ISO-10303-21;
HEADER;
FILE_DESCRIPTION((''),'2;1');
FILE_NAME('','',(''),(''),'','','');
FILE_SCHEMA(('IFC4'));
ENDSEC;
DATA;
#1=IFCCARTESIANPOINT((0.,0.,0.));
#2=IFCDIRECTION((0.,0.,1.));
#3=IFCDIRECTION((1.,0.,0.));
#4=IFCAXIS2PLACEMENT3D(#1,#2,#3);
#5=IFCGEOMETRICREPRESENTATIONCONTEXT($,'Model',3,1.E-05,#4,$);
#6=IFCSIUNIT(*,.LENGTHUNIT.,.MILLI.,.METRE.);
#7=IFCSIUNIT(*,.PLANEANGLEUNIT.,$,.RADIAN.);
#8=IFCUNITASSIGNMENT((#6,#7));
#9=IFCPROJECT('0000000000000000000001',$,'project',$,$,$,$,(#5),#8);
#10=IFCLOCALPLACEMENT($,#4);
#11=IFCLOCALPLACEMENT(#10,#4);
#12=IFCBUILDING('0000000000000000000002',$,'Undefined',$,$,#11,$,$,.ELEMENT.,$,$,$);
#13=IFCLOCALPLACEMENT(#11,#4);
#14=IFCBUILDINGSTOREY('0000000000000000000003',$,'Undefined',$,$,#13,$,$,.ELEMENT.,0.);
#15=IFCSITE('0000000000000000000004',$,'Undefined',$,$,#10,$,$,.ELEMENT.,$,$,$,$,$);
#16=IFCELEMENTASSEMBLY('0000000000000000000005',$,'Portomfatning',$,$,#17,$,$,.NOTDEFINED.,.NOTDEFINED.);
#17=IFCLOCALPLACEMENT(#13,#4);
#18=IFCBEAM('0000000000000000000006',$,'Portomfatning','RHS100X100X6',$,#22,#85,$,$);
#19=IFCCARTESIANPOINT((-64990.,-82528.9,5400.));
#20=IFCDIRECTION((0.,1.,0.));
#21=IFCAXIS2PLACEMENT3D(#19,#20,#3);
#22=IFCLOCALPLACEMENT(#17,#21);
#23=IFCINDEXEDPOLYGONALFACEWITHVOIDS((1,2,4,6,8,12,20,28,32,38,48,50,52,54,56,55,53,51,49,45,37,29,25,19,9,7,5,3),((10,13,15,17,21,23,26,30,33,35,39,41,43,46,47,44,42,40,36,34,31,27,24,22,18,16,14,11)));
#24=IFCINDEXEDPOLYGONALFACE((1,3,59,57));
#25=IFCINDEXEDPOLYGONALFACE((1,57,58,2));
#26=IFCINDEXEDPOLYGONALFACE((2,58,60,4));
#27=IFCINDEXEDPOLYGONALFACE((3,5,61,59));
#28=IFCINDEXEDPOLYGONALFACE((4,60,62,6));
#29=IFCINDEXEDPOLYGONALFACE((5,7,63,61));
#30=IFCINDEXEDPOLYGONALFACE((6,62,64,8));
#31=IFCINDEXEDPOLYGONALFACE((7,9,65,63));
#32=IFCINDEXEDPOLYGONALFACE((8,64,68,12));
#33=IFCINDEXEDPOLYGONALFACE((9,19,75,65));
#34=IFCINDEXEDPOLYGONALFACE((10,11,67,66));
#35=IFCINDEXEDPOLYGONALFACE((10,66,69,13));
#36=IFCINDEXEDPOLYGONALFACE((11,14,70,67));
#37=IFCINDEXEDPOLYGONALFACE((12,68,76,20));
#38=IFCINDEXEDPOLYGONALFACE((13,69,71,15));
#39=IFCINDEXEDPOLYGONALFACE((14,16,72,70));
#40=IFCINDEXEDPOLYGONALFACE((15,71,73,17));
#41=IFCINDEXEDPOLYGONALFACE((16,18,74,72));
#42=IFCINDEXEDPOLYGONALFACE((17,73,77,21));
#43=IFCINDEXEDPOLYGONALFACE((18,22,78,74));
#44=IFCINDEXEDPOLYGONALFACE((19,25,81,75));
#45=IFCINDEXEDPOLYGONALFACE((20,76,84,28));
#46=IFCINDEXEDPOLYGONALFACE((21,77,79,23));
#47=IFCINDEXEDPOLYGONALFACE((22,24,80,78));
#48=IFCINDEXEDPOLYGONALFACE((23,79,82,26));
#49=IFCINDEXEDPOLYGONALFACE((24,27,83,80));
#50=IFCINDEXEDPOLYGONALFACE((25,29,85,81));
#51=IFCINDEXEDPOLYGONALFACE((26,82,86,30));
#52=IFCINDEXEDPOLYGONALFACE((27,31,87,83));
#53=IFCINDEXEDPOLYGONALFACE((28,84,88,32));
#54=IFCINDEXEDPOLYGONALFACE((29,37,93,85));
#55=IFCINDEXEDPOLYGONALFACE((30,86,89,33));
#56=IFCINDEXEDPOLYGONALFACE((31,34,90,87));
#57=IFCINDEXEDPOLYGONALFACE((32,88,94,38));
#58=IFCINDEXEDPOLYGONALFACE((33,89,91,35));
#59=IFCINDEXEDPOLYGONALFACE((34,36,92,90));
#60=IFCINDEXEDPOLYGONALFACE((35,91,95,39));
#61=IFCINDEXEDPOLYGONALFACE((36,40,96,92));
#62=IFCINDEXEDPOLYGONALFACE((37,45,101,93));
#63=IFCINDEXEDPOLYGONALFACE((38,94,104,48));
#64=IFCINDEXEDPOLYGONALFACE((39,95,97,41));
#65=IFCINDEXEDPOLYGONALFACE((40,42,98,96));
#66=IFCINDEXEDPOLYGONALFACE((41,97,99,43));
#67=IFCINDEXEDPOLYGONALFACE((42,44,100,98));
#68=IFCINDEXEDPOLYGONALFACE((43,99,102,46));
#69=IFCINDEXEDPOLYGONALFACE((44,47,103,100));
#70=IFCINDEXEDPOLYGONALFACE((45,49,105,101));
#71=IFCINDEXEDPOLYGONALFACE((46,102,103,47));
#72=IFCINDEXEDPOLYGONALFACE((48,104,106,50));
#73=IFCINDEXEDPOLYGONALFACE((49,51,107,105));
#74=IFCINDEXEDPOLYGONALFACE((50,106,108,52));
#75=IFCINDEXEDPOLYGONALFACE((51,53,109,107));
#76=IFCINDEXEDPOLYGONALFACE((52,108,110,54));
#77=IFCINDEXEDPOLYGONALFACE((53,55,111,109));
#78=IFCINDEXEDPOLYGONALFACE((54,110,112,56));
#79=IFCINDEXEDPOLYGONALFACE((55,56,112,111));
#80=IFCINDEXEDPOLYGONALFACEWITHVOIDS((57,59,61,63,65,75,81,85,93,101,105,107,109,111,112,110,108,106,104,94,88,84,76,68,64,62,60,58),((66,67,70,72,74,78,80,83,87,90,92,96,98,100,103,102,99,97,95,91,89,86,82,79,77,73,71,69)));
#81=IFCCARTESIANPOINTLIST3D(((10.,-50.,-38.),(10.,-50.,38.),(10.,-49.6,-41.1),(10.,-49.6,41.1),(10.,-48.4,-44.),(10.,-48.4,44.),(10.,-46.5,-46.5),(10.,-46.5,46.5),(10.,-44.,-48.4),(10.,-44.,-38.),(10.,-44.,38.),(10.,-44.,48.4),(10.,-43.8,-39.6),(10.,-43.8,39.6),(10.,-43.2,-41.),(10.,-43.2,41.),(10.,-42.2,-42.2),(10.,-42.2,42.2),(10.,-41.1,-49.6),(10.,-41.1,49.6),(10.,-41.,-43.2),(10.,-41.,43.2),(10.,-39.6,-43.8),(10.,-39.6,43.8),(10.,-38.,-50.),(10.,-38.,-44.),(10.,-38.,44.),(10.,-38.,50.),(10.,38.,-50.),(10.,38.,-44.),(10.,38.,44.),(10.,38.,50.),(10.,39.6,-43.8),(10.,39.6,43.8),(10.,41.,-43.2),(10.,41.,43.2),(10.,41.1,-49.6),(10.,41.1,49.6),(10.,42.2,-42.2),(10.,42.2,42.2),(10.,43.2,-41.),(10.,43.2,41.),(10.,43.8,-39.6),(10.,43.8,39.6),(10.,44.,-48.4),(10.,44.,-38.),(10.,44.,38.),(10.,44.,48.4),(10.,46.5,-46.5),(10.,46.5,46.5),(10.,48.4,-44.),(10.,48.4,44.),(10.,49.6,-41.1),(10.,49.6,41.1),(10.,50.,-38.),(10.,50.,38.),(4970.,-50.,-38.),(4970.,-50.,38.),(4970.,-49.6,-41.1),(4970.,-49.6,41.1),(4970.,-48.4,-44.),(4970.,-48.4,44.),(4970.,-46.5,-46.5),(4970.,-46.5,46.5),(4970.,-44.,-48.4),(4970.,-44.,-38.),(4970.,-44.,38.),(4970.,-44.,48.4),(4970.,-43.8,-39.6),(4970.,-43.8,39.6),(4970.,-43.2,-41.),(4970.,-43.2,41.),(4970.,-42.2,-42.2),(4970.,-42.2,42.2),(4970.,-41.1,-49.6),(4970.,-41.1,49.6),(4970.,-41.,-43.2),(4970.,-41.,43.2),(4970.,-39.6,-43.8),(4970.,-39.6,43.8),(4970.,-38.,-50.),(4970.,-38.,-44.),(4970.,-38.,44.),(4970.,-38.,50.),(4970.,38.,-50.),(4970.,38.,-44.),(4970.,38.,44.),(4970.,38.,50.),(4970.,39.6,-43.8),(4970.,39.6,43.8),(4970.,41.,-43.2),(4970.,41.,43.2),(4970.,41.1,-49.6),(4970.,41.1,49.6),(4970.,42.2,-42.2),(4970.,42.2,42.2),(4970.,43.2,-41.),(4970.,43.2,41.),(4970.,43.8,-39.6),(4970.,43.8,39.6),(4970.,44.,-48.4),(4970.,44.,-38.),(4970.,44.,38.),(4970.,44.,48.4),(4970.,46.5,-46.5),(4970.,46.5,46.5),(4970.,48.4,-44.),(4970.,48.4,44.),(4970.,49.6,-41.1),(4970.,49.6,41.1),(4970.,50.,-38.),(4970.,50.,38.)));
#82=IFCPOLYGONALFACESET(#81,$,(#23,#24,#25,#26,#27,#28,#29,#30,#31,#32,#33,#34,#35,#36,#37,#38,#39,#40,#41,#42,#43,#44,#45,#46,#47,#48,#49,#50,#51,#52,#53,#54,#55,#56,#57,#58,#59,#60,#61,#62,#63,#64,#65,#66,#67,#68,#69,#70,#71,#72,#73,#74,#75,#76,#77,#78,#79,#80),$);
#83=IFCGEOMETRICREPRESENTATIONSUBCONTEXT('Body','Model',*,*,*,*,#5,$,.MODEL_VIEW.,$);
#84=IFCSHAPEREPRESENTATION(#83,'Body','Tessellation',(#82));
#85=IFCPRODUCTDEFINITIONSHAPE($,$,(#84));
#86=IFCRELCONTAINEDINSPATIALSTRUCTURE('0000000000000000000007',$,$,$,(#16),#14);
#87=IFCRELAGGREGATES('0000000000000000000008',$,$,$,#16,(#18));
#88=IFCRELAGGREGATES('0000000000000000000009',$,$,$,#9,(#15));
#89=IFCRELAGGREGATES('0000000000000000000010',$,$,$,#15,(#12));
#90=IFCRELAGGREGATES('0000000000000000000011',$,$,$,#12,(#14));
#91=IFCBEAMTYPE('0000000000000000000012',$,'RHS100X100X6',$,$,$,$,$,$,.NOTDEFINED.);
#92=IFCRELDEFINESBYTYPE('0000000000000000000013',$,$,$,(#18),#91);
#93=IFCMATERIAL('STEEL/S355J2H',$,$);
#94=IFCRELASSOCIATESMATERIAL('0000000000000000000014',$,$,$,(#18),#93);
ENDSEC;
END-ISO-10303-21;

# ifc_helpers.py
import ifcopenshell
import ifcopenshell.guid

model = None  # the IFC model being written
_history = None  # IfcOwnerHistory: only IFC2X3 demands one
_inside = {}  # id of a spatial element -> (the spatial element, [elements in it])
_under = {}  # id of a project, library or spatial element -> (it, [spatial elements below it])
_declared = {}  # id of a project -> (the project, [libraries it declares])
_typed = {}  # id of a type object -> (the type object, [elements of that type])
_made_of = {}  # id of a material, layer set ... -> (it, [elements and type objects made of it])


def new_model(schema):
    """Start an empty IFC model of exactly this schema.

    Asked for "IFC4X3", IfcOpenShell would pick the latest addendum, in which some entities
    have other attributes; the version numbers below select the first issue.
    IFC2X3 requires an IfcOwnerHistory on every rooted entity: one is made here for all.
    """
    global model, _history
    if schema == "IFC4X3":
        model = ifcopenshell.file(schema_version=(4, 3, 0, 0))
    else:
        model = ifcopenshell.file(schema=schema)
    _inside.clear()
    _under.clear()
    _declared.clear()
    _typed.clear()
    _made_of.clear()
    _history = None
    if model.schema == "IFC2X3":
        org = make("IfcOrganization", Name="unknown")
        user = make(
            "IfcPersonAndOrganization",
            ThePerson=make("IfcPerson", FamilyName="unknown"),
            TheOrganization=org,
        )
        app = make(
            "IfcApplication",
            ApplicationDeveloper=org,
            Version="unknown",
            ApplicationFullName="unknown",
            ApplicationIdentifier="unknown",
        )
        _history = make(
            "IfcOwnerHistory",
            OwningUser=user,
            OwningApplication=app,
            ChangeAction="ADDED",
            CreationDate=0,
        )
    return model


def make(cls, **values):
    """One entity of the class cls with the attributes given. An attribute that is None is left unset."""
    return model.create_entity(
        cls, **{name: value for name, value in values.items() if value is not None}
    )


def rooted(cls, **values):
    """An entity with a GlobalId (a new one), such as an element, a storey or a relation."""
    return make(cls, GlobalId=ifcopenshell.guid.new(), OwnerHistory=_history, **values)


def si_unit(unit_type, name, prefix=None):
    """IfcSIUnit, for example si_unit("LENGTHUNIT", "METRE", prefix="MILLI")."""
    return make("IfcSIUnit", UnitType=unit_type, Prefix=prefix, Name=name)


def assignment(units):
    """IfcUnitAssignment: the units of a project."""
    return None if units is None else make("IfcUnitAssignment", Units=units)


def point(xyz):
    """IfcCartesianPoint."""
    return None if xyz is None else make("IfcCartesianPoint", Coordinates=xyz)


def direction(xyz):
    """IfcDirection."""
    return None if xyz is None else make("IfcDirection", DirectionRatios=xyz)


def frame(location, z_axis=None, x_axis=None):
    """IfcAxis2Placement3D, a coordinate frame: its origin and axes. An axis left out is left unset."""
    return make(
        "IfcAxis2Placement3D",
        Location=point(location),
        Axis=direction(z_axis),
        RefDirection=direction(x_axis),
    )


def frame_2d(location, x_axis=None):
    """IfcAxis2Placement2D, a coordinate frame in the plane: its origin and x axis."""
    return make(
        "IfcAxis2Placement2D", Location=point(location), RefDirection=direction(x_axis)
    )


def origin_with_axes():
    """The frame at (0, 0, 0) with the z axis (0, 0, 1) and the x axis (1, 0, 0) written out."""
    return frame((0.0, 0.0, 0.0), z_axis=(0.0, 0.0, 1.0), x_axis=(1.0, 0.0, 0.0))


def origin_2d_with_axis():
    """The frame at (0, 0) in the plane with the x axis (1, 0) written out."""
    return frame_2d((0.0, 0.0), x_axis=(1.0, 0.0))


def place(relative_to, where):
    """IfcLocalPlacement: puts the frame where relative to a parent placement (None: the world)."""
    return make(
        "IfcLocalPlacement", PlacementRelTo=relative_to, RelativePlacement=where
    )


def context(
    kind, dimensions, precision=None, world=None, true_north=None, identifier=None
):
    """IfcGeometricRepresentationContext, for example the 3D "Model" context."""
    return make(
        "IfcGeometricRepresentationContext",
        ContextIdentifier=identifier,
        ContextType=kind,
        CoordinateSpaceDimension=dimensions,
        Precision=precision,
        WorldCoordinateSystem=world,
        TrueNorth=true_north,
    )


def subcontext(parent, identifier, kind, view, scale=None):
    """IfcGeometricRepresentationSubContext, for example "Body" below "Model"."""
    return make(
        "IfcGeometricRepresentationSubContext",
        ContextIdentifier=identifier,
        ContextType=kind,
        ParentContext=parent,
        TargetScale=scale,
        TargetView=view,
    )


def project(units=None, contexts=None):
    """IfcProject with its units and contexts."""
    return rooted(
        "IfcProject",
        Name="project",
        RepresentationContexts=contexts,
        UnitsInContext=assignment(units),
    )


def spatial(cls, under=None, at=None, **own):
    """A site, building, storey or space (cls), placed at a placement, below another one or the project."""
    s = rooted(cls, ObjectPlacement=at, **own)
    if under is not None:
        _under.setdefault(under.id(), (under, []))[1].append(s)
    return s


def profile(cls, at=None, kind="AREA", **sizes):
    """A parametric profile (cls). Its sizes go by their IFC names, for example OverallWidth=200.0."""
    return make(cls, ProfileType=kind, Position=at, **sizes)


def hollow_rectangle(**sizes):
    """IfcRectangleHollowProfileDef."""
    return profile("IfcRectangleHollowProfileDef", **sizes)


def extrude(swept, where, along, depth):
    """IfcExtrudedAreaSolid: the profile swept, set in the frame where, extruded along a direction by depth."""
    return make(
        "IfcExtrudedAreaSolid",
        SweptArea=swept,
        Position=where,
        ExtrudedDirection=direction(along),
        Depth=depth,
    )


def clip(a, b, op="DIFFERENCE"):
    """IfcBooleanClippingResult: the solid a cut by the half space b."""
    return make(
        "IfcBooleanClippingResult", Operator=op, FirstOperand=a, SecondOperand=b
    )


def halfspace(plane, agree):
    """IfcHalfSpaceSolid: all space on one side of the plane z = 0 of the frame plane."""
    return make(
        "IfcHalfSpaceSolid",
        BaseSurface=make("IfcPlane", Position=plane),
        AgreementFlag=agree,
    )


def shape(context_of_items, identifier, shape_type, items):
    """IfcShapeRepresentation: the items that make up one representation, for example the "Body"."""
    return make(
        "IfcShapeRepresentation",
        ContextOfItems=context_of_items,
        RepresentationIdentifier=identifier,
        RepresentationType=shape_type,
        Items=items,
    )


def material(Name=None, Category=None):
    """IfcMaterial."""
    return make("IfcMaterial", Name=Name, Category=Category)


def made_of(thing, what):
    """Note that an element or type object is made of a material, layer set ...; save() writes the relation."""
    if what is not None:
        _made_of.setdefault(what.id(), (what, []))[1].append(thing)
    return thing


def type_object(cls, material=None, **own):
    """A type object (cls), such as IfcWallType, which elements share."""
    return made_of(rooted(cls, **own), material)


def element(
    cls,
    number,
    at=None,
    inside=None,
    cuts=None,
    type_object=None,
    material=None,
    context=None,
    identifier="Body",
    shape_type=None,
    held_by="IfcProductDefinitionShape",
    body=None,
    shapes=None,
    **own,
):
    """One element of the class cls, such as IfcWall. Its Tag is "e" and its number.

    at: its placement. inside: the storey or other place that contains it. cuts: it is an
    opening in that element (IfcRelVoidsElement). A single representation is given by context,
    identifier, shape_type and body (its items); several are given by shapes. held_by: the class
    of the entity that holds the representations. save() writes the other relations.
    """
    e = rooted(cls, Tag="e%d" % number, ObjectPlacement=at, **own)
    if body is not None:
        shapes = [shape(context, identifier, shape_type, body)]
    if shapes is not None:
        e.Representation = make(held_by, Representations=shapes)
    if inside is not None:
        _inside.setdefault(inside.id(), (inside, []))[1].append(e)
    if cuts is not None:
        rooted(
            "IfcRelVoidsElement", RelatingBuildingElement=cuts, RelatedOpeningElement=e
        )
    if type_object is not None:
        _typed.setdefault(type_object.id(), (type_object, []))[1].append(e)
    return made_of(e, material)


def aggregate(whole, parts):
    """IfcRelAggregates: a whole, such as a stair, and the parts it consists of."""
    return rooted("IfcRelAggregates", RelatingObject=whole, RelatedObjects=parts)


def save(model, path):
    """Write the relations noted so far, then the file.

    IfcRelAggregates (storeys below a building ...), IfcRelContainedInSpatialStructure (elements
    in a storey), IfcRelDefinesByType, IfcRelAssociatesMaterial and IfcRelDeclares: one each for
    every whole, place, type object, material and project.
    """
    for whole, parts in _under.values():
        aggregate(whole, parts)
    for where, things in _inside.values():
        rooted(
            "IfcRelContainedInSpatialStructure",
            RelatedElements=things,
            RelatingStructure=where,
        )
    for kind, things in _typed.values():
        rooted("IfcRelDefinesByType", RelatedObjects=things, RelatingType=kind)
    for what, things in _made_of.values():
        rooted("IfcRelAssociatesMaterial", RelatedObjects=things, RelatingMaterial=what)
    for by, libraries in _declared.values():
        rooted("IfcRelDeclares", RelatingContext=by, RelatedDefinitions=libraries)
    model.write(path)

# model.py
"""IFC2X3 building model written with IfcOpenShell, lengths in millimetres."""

from ifc_helpers import new_model, si_unit, frame, origin_with_axes, origin_2d_with_axis, place, context, subcontext, project, spatial, hollow_rectangle, extrude, clip, halfspace, material, type_object, element, aggregate, save


model = new_model("IFC2X3")

# Units and contexts
model_context = context("Model", 3, precision=1e-05, world=origin_with_axes())
body_context = subcontext(model_context, "Body", "Model", "MODEL_VIEW")
ifc_project = project(units=[si_unit("LENGTHUNIT", "METRE", prefix="MILLI"), si_unit("PLANEANGLEUNIT", "RADIAN")], contexts=[model_context])

# Site, building, storey
site_placement = place(None, origin_with_axes())
site = spatial("IfcSite", under=ifc_project, at=site_placement, Name="Undefined", CompositionType="ELEMENT")
building_placement = place(site_placement, origin_with_axes())
building = spatial("IfcBuilding", under=site, at=building_placement, Name="Undefined", CompositionType="ELEMENT")
storey_placement = place(building_placement, origin_with_axes())
storey = spatial("IfcBuildingStorey", under=building, at=storey_placement, Name="Undefined", CompositionType="ELEMENT", Elevation=0.0)

# Shared definitions
ifc_material_1 = material(Name="STEEL/S355J2H")

# Element assembly, beam
assembly_1_placement = place(storey_placement, origin_with_axes())
assembly_1 = element("IfcElementAssembly", 1, at=assembly_1_placement, inside=storey, Name="Portomfatning", AssemblyPlace="NOTDEFINED", PredefinedType="NOTDEFINED")
beam_type = type_object("IfcBeamType", Name="RHS100X100X6", PredefinedType="NOTDEFINED")
beam_placement = place(assembly_1_placement, frame((-64990.0, -82528.9, 5400.0), z_axis=(0.0, 1.0, 0.0), x_axis=(1.0, 0.0, 0.0)))
beam = element("IfcBeam", 2, at=beam_placement, type_object=beam_type, material=ifc_material_1, Name="Portomfatning", Description="RHS100X100X6", context=body_context, shape_type="Clipping", body=[
    clip(clip(extrude(hollow_rectangle(XDim=100.0, YDim=100.0, WallThickness=6.0, InnerFilletRadius=6.0, OuterFilletRadius=12.0, at=origin_2d_with_axis()), frame((4980.0, 0.0, 0.0), z_axis=(-1.0, 0.0, 0.0), x_axis=(0.0, -1.0, 0.0)), (0.0, 0.0, 1.0), 4980.0), halfspace(frame((4970.0, 50.0, 0.0), z_axis=(-1.0, 0.0, 0.0), x_axis=(0.0, 0.0, 1.0)), True)), halfspace(frame((10.0, 50.0, 0.0), z_axis=(1.0, 0.0, 0.0), x_axis=(0.0, 0.0, -1.0)), True)),
])

aggregate(assembly_1, [beam])

save(model, "model.ifc")
